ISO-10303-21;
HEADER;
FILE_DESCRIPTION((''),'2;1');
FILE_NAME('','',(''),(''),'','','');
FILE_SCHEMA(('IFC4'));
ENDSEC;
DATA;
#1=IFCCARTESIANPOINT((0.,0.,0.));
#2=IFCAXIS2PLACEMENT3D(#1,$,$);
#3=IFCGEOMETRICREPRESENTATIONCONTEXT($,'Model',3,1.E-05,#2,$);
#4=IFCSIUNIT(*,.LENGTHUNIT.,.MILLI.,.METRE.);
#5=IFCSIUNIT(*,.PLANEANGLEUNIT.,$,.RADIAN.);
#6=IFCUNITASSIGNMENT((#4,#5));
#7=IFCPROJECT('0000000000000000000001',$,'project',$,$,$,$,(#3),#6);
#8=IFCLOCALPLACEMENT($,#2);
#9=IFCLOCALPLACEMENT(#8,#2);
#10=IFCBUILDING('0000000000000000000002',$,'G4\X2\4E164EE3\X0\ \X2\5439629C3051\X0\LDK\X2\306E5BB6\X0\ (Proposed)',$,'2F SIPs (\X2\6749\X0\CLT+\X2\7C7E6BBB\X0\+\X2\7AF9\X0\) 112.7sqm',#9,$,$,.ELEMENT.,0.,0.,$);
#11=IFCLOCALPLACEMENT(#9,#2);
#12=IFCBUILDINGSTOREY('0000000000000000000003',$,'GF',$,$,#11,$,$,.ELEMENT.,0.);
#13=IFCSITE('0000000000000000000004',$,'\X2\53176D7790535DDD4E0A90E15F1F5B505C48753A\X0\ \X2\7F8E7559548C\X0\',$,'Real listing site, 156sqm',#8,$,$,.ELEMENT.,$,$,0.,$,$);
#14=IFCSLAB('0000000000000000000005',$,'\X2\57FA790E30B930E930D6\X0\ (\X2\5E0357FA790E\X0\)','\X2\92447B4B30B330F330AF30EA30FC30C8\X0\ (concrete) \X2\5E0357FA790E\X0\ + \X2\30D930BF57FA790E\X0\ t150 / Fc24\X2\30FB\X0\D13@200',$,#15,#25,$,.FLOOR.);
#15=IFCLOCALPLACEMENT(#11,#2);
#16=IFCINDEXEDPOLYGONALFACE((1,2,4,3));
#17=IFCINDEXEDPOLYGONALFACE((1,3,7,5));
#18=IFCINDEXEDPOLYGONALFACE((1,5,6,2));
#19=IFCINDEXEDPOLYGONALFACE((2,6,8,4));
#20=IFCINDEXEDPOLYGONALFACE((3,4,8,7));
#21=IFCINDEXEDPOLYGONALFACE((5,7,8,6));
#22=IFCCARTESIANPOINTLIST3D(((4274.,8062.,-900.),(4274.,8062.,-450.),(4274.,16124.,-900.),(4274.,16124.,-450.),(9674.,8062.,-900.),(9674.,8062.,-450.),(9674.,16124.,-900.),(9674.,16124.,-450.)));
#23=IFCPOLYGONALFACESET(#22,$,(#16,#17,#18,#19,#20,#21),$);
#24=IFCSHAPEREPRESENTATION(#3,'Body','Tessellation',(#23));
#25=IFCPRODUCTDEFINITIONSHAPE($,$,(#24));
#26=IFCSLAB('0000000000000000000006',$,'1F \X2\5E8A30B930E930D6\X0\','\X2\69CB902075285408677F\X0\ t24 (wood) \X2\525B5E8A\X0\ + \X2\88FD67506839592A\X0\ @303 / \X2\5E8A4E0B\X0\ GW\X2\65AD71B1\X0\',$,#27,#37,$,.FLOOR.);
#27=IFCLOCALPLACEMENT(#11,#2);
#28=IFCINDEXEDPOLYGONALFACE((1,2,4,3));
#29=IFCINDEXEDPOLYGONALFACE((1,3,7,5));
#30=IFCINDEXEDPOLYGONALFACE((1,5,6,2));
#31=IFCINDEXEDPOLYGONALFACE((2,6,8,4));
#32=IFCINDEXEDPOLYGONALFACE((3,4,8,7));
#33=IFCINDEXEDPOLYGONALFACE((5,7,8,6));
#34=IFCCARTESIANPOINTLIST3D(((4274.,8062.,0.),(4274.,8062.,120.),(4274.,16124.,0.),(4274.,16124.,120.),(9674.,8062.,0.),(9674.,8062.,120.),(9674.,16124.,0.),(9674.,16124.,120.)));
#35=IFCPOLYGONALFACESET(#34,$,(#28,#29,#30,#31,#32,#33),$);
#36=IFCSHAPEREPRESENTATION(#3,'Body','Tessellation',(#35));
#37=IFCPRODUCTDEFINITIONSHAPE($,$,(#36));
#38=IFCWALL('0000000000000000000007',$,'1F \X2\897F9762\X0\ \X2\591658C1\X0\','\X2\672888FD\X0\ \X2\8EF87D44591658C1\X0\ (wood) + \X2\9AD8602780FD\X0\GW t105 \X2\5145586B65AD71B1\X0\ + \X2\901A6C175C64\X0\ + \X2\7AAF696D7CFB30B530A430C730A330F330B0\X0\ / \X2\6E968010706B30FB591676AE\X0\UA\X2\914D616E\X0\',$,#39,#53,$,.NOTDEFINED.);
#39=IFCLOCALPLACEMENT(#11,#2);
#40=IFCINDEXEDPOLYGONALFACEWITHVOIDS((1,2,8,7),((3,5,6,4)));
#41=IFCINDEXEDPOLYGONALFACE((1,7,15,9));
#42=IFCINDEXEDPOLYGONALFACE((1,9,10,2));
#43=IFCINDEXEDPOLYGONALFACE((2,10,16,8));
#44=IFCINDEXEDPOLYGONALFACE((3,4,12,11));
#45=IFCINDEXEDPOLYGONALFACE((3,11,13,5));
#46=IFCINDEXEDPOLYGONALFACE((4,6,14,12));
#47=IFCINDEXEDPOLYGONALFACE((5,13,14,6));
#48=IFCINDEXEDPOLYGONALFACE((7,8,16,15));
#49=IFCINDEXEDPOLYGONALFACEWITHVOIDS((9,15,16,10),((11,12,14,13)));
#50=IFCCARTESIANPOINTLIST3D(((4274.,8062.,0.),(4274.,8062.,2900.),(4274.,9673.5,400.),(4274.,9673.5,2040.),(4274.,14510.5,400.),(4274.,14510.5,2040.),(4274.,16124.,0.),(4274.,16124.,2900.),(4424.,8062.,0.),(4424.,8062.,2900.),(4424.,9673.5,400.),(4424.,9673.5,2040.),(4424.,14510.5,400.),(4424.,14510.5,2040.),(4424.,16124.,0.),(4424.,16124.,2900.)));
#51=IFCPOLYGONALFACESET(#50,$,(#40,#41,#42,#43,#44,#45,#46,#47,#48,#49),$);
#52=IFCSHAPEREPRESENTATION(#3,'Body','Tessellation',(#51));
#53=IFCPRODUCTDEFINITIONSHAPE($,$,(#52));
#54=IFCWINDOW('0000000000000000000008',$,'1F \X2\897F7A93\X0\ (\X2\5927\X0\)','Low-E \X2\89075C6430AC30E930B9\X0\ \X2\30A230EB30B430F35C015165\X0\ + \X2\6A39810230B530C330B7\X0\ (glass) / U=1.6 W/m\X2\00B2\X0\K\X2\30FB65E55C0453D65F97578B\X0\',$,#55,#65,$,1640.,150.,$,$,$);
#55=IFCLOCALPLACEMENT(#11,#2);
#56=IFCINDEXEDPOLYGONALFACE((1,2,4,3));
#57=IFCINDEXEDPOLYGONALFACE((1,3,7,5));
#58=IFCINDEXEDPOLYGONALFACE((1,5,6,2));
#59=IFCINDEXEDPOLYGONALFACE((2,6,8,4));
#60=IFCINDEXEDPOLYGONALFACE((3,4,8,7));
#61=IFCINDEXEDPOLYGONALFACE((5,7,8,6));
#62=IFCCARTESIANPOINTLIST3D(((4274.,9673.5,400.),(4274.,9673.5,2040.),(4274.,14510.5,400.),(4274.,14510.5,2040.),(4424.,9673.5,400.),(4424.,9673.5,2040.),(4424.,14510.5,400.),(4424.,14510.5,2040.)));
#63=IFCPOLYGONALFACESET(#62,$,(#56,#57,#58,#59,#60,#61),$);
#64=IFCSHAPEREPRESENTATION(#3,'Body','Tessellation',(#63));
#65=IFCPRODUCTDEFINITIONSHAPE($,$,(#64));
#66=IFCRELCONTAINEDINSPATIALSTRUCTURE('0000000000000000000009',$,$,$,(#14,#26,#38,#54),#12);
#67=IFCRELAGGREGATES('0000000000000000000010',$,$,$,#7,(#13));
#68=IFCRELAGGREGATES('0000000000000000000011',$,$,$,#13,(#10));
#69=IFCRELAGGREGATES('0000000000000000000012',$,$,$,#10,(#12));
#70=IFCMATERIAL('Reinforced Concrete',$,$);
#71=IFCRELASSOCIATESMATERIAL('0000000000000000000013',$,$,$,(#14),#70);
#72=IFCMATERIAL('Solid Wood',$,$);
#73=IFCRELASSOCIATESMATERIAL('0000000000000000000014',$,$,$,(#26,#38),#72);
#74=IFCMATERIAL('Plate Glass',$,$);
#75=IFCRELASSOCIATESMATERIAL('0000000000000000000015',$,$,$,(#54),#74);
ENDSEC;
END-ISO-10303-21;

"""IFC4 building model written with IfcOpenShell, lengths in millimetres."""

from ifc_helpers import new_model, si_unit, frame, frame_2d, origin, place, context, project, spatial, rectangle, extrude, material, element, fill, save


model = new_model("IFC4")

# Units and contexts
model_context = context("Model", 3, precision=1e-05, world=origin())
ifc_project = project(units=[si_unit("LENGTHUNIT", "METRE", prefix="MILLI"), si_unit("PLANEANGLEUNIT", "RADIAN")], contexts=[model_context])

# Site, building, storey
site_placement = place(None, origin())
site = spatial("IfcSite", under=ifc_project, at=site_placement, Name="北海道川上郡弟子屈町 美留和", ObjectType="Real listing site, 156sqm", CompositionType="ELEMENT", RefElevation=0.0)
building_placement = place(site_placement, origin())
building = spatial("IfcBuilding", under=site, at=building_placement, Name="G4世代 吹抜けLDKの家 (Proposed)", ObjectType="2F SIPs (杉CLT+籾殻+竹) 112.7sqm", CompositionType="ELEMENT", ElevationOfRefHeight=0.0, ElevationOfTerrain=0.0)
storey_placement = place(building_placement, origin())
storey = spatial("IfcBuildingStorey", under=building, at=storey_placement, Name="GF", CompositionType="ELEMENT", Elevation=0.0)

# Slabs
ifc_material_1 = material(Name="Reinforced Concrete")
slab_1_placement = place(storey_placement, frame((2137.0, 4031.0, -450.0)))
element("IfcSlab", 1, at=slab_1_placement, inside=storey, material=ifc_material_1, Name="基礎スラブ (布基礎)", Description="鉄筋コンクリート (concrete) 布基礎 + ベタ基礎 t150 / Fc24・D13@200", PredefinedType="FLOOR", context=model_context, shape_type="SweptSolid", body=[
    extrude(rectangle(XDim=5400.0, YDim=8062.0, at=frame_2d((2700.0, 4031.0))), frame((2137.0, 4031.0, -450.0)), (0.0, 0.0, 1.0), 450.0),
])
ifc_material_2 = material(Name="Solid Wood")
slab_2_placement = place(storey_placement, frame((2137.0, 4031.0, 0.0)))
element("IfcSlab", 2, at=slab_2_placement, inside=storey, material=ifc_material_2, Name="1F 床スラブ", Description="構造用合板 t24 (wood) 剛床 + 製材根太 @303 / 床下 GW断熱", PredefinedType="FLOOR", context=model_context, shape_type="SweptSolid", body=[
    extrude(rectangle(XDim=5400.0, YDim=8062.0, at=frame_2d((2700.0, 4031.0))), frame((2137.0, 4031.0, 0.0)), (0.0, 0.0, 1.0), 120.0),
])

# Shared definitions
ifc_material_3 = material(Name="Plate Glass")

# Wall, opening, window
wall_1_placement = place(storey_placement, frame((2137.0, 4031.0, 0.0)))
wall_1 = element("IfcWall", 3, at=wall_1_placement, inside=storey, material=ifc_material_2, Name="1F 西面 外壁", Description="木製 軸組外壁 (wood) + 高性能GW t105 充填断熱 + 通気層 + 窯業系サイディング / 準耐火・外皮UA配慮", PredefinedType="NOTDEFINED", context=model_context, shape_type="SweptSolid", body=[
    extrude(rectangle(XDim=150.0, YDim=8062.0, at=frame_2d((75.0, 4031.0))), frame((2137.0, 4031.0, 0.0)), (0.0, 0.0, 1.0), 2900.0),
])
opening_1_placement = place(storey_placement, frame((2137.0, 4837.0, 200.0)))
opening_1 = element("IfcOpeningElement", 4, at=opening_1_placement, cuts=wall_1, PredefinedType="NOTDEFINED", context=model_context, shape_type="SweptSolid", body=[
    extrude(rectangle(XDim=150.0, YDim=4837.0, at=frame_2d((75.0, 2418.0))), frame((2137.0, 4837.0, 200.0)), (0.0, 0.0, 1.0), 1640.0),
])
window_1_placement = place(storey_placement, frame((2137.0, 4837.0, 200.0)))
window_1 = element("IfcWindow", 5, at=window_1_placement, inside=storey, material=ifc_material_3, Name="1F 西窓 (大)", Description="Low-E 複層ガラス アルゴン封入 + 樹脂サッシ (glass) / U=1.6 W/m²K・日射取得型", OverallHeight=1640.0, OverallWidth=150.0, context=model_context, shape_type="SweptSolid", body=[
    extrude(rectangle(XDim=150.0, YDim=4837.0, at=frame_2d((75.0, 2418.0))), frame((2137.0, 4837.0, 200.0)), (0.0, 0.0, 1.0), 1640.0),
])
fill(opening_1, window_1)

save(model, "model.ifc")
